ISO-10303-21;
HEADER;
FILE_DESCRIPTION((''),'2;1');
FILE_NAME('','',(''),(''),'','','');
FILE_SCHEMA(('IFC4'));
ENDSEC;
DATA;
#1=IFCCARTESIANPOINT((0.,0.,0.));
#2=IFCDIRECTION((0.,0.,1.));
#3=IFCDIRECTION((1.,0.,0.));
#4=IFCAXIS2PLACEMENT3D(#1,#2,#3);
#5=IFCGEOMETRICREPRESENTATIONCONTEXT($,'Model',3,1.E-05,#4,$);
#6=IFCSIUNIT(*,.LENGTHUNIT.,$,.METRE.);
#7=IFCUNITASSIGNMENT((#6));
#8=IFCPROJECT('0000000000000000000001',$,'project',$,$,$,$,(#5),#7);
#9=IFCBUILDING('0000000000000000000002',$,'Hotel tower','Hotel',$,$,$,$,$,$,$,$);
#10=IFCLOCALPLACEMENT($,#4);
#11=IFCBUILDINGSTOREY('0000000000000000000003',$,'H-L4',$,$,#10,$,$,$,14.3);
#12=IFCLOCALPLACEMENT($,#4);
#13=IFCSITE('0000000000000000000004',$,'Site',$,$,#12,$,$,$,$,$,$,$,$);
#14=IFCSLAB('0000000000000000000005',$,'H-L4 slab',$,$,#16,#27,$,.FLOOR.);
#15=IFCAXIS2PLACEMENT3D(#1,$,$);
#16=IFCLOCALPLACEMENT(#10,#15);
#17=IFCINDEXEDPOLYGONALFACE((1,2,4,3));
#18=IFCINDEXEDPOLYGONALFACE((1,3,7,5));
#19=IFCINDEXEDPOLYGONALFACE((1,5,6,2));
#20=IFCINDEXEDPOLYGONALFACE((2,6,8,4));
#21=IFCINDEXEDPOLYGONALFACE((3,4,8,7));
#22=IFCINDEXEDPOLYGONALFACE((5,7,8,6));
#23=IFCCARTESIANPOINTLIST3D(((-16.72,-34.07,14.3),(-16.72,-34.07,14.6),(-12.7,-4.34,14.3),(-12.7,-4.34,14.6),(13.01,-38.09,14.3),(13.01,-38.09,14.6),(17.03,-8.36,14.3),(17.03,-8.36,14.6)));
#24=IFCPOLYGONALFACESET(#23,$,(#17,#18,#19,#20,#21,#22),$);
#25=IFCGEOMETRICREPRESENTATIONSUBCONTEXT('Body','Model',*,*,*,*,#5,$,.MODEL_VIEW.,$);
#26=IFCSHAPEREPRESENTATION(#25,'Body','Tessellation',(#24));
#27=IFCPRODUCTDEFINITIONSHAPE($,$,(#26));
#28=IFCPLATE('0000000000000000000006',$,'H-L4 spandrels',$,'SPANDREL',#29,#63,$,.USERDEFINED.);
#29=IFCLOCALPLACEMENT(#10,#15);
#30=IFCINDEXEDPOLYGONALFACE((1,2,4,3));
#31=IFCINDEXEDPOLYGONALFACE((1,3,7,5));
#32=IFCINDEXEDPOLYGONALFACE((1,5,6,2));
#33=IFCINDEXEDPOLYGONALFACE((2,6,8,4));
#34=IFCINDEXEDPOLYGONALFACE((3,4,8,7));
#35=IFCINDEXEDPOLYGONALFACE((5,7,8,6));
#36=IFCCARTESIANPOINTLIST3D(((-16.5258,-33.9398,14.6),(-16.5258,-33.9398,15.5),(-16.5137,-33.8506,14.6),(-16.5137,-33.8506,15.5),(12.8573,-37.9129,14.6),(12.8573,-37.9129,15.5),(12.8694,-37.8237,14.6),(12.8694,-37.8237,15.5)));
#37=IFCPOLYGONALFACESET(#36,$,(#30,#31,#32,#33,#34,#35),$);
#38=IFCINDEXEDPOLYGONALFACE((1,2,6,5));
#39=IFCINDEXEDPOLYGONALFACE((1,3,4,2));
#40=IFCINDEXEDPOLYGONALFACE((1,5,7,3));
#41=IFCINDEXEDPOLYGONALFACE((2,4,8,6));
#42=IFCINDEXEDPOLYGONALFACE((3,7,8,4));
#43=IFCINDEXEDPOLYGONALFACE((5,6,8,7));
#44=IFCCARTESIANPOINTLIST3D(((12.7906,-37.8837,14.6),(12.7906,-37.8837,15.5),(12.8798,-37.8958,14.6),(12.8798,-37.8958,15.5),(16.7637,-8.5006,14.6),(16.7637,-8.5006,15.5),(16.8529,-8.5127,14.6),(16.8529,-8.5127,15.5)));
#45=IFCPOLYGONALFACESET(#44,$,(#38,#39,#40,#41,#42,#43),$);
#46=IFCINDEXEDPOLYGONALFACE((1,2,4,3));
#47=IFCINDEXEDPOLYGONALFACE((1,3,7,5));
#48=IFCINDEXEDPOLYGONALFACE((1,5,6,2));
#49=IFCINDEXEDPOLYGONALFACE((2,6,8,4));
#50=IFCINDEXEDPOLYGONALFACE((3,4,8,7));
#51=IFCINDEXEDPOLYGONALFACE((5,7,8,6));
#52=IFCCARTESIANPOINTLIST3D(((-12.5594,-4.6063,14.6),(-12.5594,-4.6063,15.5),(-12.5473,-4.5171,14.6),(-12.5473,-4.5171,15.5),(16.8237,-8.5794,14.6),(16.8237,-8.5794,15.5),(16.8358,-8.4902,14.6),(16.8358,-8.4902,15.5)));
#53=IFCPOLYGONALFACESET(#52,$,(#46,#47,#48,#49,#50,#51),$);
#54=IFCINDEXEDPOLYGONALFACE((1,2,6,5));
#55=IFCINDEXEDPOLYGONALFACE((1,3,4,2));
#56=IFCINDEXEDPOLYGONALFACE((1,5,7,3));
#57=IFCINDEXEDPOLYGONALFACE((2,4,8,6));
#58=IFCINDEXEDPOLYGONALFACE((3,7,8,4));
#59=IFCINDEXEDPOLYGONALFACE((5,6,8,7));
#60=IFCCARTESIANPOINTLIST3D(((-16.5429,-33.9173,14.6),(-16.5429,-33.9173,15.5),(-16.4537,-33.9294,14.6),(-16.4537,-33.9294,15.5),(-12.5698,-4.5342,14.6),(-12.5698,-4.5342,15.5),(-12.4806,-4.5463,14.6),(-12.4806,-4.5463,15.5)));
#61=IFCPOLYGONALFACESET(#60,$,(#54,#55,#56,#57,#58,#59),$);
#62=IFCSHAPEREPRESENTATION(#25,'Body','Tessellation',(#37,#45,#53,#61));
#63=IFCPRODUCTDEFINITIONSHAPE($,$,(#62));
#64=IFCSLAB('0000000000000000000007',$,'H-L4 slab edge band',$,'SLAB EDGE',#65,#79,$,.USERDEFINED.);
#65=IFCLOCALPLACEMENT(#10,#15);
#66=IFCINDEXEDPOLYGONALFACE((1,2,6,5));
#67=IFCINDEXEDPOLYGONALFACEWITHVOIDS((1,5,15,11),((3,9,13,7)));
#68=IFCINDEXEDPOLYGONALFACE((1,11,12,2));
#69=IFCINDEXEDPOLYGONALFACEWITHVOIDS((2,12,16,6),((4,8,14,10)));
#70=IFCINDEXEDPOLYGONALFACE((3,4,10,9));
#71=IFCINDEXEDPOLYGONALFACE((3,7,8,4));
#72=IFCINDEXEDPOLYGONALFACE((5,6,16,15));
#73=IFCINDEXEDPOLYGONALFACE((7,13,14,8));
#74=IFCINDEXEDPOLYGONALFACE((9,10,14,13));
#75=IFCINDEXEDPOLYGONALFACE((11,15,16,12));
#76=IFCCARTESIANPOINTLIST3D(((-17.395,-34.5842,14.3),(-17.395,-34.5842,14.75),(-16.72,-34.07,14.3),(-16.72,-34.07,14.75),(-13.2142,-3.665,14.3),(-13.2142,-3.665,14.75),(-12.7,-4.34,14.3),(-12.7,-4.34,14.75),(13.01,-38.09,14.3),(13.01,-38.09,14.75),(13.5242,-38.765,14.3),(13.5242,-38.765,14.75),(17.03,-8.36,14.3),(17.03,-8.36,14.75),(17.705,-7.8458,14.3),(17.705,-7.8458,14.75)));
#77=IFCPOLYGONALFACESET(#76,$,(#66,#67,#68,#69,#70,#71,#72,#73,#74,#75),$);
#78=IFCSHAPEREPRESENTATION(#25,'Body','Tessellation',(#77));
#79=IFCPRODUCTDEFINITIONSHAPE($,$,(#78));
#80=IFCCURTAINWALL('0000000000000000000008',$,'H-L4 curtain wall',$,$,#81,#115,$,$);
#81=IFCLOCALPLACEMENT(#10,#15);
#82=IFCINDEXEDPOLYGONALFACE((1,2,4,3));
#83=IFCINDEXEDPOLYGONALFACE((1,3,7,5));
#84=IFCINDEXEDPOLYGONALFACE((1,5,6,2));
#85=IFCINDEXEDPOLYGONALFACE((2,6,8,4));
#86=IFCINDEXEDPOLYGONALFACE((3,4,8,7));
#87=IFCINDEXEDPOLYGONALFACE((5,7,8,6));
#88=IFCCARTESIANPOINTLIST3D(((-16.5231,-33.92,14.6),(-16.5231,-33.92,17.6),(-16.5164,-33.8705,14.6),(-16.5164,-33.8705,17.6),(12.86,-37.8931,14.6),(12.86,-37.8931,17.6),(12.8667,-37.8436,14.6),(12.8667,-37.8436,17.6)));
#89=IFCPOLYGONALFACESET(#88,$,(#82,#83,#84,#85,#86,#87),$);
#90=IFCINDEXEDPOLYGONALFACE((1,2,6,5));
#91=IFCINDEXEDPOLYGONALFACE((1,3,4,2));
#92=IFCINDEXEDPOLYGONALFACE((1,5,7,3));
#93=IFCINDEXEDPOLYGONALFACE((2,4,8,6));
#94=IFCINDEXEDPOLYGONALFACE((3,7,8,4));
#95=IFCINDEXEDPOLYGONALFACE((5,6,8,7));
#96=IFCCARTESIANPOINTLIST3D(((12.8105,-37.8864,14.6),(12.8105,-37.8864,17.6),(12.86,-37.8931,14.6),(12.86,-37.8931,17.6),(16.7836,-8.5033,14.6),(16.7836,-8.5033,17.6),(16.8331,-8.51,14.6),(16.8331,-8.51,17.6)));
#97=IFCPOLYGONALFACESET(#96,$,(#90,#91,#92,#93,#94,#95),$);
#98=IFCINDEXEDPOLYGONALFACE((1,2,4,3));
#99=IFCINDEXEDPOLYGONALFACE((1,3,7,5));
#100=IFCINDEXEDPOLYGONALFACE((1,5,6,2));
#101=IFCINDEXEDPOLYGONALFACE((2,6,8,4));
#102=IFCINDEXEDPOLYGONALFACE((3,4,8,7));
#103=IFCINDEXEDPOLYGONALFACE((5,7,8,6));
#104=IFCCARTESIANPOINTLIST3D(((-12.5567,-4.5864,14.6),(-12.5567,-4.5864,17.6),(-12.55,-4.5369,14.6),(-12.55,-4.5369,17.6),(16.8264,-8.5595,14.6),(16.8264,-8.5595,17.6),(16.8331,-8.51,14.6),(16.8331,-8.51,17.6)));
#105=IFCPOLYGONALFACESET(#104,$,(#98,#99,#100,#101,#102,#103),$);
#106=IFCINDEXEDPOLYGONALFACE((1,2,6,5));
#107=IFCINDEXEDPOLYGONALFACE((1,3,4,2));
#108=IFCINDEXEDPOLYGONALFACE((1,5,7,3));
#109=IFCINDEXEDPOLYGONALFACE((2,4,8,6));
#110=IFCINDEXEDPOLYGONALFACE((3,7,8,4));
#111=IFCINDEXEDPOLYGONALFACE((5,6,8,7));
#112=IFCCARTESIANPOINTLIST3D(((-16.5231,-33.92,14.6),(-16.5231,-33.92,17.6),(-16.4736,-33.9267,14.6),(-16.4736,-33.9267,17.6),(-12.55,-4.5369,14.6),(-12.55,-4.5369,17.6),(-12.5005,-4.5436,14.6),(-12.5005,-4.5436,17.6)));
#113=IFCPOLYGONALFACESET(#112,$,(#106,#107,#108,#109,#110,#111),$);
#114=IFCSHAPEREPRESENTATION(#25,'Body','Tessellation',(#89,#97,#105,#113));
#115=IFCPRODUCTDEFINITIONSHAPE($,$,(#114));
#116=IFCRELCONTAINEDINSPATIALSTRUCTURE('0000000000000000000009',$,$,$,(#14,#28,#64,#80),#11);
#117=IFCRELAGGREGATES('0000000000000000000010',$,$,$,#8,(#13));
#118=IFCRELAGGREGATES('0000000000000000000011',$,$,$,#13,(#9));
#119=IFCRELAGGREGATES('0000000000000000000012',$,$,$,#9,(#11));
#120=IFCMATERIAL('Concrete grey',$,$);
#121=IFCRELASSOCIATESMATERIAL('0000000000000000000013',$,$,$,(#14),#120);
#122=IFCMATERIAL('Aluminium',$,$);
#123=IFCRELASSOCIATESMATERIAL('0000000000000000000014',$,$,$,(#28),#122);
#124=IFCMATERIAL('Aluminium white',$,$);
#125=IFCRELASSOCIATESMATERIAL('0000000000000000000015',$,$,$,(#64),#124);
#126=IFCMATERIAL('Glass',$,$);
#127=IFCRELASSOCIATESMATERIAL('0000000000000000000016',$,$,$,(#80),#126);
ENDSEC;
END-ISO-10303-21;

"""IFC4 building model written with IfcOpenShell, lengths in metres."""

from ifc_helpers import new_model, si_unit, frame, origin_with_axes, place, context, subcontext, project, spatial, polyline, outline, extrude, material, element, save


model = new_model("IFC4")

# Units and contexts
model_context = context("Model", 3, precision=1e-05, world=origin_with_axes())
body_context = subcontext(model_context, "Body", "Model", "MODEL_VIEW")
ifc_project = project(units=[si_unit("LENGTHUNIT", "METRE")], contexts=[model_context])

# Site, building, storey
site_placement = place(None, origin_with_axes())
site = spatial("IfcSite", under=ifc_project, at=site_placement, Name="Site")
building = spatial("IfcBuilding", under=site, Name="Hotel tower", Description="Hotel")
storey_placement = place(None, origin_with_axes())
storey = spatial("IfcBuildingStorey", under=building, at=storey_placement, Name="H-L4", Elevation=14.3)

# Shared definitions
ifc_material_1 = material(Name="Aluminium")

# Slab
ifc_material_2 = material(Name="Concrete grey")
slab_1_placement = place(storey_placement, origin_with_axes())
element("IfcSlab", 1, at=slab_1_placement, inside=storey, material=ifc_material_2, Name="H-L4 slab", PredefinedType="FLOOR", context=body_context, shape_type="SweptSolid", body=[
    extrude(outline(polyline([(-16.72, -34.07), (13.01, -38.09), (17.03, -8.36), (-12.7, -4.34), (-16.72, -34.07)])), frame((0.0, 0.0, 14.3), z_axis=(0.0, 0.0, 1.0), x_axis=(1.0, 0.0, 0.0)), (0.0, 0.0, 1.0), 0.3),
])

# Plate
plate_placement = place(storey_placement, origin_with_axes())
element("IfcPlate", 2, at=plate_placement, inside=storey, material=ifc_material_1, Name="H-L4 spandrels", ObjectType="SPANDREL", PredefinedType="USERDEFINED", context=body_context, shape_type="SweptSolid", body=[
    extrude(outline(polyline([(-16.5258, -33.9398), (12.8573, -37.9129), (12.8694, -37.8237), (-16.5137, -33.8506), (-16.5258, -33.9398)])), frame((0.0, 0.0, 14.6), z_axis=(0.0, 0.0, 1.0), x_axis=(1.0, 0.0, 0.0)), (0.0, 0.0, 1.0), 0.9),
    extrude(outline(polyline([(12.8798, -37.8958), (16.8529, -8.5127), (16.7637, -8.5006), (12.7906, -37.8837), (12.8798, -37.8958)])), frame((0.0, 0.0, 14.6), z_axis=(0.0, 0.0, 1.0), x_axis=(1.0, 0.0, 0.0)), (0.0, 0.0, 1.0), 0.9),
    extrude(outline(polyline([(16.8358, -8.4902), (-12.5473, -4.5171), (-12.5594, -4.6063), (16.8237, -8.5794), (16.8358, -8.4902)])), frame((0.0, 0.0, 14.6), z_axis=(0.0, 0.0, 1.0), x_axis=(1.0, 0.0, 0.0)), (0.0, 0.0, 1.0), 0.9),
    extrude(outline(polyline([(-12.5698, -4.5342), (-16.5429, -33.9173), (-16.4537, -33.9294), (-12.4806, -4.5463), (-12.5698, -4.5342)])), frame((0.0, 0.0, 14.6), z_axis=(0.0, 0.0, 1.0), x_axis=(1.0, 0.0, 0.0)), (0.0, 0.0, 1.0), 0.9),
])

# Slab
ifc_material_3 = material(Name="Aluminium white")
slab_2_placement = place(storey_placement, origin_with_axes())
element("IfcSlab", 3, at=slab_2_placement, inside=storey, material=ifc_material_3, Name="H-L4 slab edge band", ObjectType="SLAB EDGE", PredefinedType="USERDEFINED", context=body_context, shape_type="SweptSolid", body=[
    extrude(outline(polyline([(-17.395, -34.5842), (13.5242, -38.765), (17.705, -7.8458), (-13.2142, -3.665), (-17.395, -34.5842)]), holes=[polyline([(-16.72, -34.07), (13.01, -38.09), (17.03, -8.36), (-12.7, -4.34), (-16.72, -34.07)])]), frame((0.0, 0.0, 14.3), z_axis=(0.0, 0.0, 1.0), x_axis=(1.0, 0.0, 0.0)), (0.0, 0.0, 1.0), 0.45),
])

# Curtain wall
ifc_material_4 = material(Name="Glass")
curtain_wall_placement = place(storey_placement, origin_with_axes())
element("IfcCurtainWall", 4, at=curtain_wall_placement, inside=storey, material=ifc_material_4, Name="H-L4 curtain wall", context=body_context, shape_type="SweptSolid", body=[
    extrude(outline(polyline([(-16.5231, -33.92), (12.86, -37.8931), (12.8667, -37.8436), (-16.5164, -33.8705), (-16.5231, -33.92)])), frame((0.0, 0.0, 14.6), z_axis=(0.0, 0.0, 1.0), x_axis=(1.0, 0.0, 0.0)), (0.0, 0.0, 1.0), 3.0),
    extrude(outline(polyline([(12.86, -37.8931), (16.8331, -8.51), (16.7836, -8.5033), (12.8105, -37.8864), (12.86, -37.8931)])), frame((0.0, 0.0, 14.6), z_axis=(0.0, 0.0, 1.0), x_axis=(1.0, 0.0, 0.0)), (0.0, 0.0, 1.0), 3.0),
    extrude(outline(polyline([(16.8331, -8.51), (-12.55, -4.5369), (-12.5567, -4.5864), (16.8264, -8.5595), (16.8331, -8.51)])), frame((0.0, 0.0, 14.6), z_axis=(0.0, 0.0, 1.0), x_axis=(1.0, 0.0, 0.0)), (0.0, 0.0, 1.0), 3.0),
    extrude(outline(polyline([(-12.55, -4.5369), (-16.5231, -33.92), (-16.4736, -33.9267), (-12.5005, -4.5436), (-12.55, -4.5369)])), frame((0.0, 0.0, 14.6), z_axis=(0.0, 0.0, 1.0), x_axis=(1.0, 0.0, 0.0)), (0.0, 0.0, 1.0), 3.0),
])

save(model, "model.ifc")
